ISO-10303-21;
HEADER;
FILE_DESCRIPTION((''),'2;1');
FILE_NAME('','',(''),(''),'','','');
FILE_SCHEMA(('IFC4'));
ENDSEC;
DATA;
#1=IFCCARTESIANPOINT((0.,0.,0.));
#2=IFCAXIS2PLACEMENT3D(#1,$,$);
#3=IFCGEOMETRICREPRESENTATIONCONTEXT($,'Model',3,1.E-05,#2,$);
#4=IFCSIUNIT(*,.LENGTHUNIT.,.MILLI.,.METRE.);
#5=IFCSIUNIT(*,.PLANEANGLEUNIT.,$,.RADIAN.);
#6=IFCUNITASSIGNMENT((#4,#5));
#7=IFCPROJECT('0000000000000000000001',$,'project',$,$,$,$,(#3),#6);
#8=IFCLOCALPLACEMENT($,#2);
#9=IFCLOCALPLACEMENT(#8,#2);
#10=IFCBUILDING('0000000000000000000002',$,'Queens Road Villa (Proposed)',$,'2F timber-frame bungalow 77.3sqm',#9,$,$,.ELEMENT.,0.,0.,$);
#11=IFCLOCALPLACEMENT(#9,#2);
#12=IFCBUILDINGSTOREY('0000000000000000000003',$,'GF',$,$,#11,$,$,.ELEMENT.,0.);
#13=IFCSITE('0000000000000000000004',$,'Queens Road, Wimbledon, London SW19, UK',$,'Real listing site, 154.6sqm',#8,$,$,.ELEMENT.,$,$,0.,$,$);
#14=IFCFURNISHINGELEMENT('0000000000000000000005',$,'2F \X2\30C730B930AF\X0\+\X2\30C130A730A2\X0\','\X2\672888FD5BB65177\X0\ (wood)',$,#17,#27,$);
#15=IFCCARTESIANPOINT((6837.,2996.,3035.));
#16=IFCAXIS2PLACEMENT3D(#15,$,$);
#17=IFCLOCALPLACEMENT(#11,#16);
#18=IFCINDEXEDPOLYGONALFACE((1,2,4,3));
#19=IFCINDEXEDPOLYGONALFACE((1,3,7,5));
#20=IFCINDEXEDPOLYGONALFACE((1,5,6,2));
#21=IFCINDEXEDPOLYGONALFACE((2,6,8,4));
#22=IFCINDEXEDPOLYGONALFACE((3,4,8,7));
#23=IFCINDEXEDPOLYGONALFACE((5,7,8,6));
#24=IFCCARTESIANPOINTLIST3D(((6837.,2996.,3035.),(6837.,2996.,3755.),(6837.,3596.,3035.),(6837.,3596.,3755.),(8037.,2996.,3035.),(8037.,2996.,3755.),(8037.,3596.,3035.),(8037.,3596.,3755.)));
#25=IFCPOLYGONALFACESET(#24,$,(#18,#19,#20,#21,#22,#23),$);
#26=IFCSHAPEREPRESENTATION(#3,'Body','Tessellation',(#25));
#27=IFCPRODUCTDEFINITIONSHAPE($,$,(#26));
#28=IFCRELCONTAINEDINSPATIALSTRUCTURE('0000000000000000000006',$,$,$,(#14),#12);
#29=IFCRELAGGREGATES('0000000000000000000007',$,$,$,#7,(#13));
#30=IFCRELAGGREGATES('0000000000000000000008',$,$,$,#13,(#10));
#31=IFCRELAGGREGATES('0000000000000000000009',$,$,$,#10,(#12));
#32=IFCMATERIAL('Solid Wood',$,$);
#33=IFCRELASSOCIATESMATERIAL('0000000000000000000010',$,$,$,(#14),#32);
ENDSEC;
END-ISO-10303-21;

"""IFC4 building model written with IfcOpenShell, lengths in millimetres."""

from ifc_helpers import new_model, si_unit, frame, frame_2d, origin, place, context, project, spatial, rectangle, extrude, material, element, save


model = new_model("IFC4")

# Units and contexts
model_context = context("Model", 3, precision=1e-05, world=origin())
ifc_project = project(units=[si_unit("LENGTHUNIT", "METRE", prefix="MILLI"), si_unit("PLANEANGLEUNIT", "RADIAN")], contexts=[model_context])

# Site, building, storey
site_placement = place(None, origin())
site = spatial("IfcSite", under=ifc_project, at=site_placement, Name="Queens Road, Wimbledon, London SW19, UK", ObjectType="Real listing site, 154.6sqm", CompositionType="ELEMENT", RefElevation=0.0)
building_placement = place(site_placement, origin())
building = spatial("IfcBuilding", under=site, at=building_placement, Name="Queens Road Villa (Proposed)", ObjectType="2F timber-frame bungalow 77.3sqm", CompositionType="ELEMENT", ElevationOfRefHeight=0.0, ElevationOfTerrain=0.0)
storey_placement = place(building_placement, origin())
storey = spatial("IfcBuildingStorey", under=building, at=storey_placement, Name="GF", CompositionType="ELEMENT", Elevation=0.0)

# Shared definitions
ifc_material_1 = material(Name="Solid Wood")

# Furnishing element
furnishing_1_placement = place(storey_placement, frame((6837.0, 2996.0, 3035.0)))
element("IfcFurnishingElement", 1, at=furnishing_1_placement, inside=storey, material=ifc_material_1, Name="2F デスク+チェア", Description="木製家具 (wood)", context=model_context, shape_type="SweptSolid", body=[
    extrude(rectangle(XDim=1200.0, YDim=600.0, at=frame_2d((600.0, 300.0))), frame((6837.0, 2996.0, 3035.0)), (0.0, 0.0, 1.0), 720.0),
])

save(model, "model.ifc")
